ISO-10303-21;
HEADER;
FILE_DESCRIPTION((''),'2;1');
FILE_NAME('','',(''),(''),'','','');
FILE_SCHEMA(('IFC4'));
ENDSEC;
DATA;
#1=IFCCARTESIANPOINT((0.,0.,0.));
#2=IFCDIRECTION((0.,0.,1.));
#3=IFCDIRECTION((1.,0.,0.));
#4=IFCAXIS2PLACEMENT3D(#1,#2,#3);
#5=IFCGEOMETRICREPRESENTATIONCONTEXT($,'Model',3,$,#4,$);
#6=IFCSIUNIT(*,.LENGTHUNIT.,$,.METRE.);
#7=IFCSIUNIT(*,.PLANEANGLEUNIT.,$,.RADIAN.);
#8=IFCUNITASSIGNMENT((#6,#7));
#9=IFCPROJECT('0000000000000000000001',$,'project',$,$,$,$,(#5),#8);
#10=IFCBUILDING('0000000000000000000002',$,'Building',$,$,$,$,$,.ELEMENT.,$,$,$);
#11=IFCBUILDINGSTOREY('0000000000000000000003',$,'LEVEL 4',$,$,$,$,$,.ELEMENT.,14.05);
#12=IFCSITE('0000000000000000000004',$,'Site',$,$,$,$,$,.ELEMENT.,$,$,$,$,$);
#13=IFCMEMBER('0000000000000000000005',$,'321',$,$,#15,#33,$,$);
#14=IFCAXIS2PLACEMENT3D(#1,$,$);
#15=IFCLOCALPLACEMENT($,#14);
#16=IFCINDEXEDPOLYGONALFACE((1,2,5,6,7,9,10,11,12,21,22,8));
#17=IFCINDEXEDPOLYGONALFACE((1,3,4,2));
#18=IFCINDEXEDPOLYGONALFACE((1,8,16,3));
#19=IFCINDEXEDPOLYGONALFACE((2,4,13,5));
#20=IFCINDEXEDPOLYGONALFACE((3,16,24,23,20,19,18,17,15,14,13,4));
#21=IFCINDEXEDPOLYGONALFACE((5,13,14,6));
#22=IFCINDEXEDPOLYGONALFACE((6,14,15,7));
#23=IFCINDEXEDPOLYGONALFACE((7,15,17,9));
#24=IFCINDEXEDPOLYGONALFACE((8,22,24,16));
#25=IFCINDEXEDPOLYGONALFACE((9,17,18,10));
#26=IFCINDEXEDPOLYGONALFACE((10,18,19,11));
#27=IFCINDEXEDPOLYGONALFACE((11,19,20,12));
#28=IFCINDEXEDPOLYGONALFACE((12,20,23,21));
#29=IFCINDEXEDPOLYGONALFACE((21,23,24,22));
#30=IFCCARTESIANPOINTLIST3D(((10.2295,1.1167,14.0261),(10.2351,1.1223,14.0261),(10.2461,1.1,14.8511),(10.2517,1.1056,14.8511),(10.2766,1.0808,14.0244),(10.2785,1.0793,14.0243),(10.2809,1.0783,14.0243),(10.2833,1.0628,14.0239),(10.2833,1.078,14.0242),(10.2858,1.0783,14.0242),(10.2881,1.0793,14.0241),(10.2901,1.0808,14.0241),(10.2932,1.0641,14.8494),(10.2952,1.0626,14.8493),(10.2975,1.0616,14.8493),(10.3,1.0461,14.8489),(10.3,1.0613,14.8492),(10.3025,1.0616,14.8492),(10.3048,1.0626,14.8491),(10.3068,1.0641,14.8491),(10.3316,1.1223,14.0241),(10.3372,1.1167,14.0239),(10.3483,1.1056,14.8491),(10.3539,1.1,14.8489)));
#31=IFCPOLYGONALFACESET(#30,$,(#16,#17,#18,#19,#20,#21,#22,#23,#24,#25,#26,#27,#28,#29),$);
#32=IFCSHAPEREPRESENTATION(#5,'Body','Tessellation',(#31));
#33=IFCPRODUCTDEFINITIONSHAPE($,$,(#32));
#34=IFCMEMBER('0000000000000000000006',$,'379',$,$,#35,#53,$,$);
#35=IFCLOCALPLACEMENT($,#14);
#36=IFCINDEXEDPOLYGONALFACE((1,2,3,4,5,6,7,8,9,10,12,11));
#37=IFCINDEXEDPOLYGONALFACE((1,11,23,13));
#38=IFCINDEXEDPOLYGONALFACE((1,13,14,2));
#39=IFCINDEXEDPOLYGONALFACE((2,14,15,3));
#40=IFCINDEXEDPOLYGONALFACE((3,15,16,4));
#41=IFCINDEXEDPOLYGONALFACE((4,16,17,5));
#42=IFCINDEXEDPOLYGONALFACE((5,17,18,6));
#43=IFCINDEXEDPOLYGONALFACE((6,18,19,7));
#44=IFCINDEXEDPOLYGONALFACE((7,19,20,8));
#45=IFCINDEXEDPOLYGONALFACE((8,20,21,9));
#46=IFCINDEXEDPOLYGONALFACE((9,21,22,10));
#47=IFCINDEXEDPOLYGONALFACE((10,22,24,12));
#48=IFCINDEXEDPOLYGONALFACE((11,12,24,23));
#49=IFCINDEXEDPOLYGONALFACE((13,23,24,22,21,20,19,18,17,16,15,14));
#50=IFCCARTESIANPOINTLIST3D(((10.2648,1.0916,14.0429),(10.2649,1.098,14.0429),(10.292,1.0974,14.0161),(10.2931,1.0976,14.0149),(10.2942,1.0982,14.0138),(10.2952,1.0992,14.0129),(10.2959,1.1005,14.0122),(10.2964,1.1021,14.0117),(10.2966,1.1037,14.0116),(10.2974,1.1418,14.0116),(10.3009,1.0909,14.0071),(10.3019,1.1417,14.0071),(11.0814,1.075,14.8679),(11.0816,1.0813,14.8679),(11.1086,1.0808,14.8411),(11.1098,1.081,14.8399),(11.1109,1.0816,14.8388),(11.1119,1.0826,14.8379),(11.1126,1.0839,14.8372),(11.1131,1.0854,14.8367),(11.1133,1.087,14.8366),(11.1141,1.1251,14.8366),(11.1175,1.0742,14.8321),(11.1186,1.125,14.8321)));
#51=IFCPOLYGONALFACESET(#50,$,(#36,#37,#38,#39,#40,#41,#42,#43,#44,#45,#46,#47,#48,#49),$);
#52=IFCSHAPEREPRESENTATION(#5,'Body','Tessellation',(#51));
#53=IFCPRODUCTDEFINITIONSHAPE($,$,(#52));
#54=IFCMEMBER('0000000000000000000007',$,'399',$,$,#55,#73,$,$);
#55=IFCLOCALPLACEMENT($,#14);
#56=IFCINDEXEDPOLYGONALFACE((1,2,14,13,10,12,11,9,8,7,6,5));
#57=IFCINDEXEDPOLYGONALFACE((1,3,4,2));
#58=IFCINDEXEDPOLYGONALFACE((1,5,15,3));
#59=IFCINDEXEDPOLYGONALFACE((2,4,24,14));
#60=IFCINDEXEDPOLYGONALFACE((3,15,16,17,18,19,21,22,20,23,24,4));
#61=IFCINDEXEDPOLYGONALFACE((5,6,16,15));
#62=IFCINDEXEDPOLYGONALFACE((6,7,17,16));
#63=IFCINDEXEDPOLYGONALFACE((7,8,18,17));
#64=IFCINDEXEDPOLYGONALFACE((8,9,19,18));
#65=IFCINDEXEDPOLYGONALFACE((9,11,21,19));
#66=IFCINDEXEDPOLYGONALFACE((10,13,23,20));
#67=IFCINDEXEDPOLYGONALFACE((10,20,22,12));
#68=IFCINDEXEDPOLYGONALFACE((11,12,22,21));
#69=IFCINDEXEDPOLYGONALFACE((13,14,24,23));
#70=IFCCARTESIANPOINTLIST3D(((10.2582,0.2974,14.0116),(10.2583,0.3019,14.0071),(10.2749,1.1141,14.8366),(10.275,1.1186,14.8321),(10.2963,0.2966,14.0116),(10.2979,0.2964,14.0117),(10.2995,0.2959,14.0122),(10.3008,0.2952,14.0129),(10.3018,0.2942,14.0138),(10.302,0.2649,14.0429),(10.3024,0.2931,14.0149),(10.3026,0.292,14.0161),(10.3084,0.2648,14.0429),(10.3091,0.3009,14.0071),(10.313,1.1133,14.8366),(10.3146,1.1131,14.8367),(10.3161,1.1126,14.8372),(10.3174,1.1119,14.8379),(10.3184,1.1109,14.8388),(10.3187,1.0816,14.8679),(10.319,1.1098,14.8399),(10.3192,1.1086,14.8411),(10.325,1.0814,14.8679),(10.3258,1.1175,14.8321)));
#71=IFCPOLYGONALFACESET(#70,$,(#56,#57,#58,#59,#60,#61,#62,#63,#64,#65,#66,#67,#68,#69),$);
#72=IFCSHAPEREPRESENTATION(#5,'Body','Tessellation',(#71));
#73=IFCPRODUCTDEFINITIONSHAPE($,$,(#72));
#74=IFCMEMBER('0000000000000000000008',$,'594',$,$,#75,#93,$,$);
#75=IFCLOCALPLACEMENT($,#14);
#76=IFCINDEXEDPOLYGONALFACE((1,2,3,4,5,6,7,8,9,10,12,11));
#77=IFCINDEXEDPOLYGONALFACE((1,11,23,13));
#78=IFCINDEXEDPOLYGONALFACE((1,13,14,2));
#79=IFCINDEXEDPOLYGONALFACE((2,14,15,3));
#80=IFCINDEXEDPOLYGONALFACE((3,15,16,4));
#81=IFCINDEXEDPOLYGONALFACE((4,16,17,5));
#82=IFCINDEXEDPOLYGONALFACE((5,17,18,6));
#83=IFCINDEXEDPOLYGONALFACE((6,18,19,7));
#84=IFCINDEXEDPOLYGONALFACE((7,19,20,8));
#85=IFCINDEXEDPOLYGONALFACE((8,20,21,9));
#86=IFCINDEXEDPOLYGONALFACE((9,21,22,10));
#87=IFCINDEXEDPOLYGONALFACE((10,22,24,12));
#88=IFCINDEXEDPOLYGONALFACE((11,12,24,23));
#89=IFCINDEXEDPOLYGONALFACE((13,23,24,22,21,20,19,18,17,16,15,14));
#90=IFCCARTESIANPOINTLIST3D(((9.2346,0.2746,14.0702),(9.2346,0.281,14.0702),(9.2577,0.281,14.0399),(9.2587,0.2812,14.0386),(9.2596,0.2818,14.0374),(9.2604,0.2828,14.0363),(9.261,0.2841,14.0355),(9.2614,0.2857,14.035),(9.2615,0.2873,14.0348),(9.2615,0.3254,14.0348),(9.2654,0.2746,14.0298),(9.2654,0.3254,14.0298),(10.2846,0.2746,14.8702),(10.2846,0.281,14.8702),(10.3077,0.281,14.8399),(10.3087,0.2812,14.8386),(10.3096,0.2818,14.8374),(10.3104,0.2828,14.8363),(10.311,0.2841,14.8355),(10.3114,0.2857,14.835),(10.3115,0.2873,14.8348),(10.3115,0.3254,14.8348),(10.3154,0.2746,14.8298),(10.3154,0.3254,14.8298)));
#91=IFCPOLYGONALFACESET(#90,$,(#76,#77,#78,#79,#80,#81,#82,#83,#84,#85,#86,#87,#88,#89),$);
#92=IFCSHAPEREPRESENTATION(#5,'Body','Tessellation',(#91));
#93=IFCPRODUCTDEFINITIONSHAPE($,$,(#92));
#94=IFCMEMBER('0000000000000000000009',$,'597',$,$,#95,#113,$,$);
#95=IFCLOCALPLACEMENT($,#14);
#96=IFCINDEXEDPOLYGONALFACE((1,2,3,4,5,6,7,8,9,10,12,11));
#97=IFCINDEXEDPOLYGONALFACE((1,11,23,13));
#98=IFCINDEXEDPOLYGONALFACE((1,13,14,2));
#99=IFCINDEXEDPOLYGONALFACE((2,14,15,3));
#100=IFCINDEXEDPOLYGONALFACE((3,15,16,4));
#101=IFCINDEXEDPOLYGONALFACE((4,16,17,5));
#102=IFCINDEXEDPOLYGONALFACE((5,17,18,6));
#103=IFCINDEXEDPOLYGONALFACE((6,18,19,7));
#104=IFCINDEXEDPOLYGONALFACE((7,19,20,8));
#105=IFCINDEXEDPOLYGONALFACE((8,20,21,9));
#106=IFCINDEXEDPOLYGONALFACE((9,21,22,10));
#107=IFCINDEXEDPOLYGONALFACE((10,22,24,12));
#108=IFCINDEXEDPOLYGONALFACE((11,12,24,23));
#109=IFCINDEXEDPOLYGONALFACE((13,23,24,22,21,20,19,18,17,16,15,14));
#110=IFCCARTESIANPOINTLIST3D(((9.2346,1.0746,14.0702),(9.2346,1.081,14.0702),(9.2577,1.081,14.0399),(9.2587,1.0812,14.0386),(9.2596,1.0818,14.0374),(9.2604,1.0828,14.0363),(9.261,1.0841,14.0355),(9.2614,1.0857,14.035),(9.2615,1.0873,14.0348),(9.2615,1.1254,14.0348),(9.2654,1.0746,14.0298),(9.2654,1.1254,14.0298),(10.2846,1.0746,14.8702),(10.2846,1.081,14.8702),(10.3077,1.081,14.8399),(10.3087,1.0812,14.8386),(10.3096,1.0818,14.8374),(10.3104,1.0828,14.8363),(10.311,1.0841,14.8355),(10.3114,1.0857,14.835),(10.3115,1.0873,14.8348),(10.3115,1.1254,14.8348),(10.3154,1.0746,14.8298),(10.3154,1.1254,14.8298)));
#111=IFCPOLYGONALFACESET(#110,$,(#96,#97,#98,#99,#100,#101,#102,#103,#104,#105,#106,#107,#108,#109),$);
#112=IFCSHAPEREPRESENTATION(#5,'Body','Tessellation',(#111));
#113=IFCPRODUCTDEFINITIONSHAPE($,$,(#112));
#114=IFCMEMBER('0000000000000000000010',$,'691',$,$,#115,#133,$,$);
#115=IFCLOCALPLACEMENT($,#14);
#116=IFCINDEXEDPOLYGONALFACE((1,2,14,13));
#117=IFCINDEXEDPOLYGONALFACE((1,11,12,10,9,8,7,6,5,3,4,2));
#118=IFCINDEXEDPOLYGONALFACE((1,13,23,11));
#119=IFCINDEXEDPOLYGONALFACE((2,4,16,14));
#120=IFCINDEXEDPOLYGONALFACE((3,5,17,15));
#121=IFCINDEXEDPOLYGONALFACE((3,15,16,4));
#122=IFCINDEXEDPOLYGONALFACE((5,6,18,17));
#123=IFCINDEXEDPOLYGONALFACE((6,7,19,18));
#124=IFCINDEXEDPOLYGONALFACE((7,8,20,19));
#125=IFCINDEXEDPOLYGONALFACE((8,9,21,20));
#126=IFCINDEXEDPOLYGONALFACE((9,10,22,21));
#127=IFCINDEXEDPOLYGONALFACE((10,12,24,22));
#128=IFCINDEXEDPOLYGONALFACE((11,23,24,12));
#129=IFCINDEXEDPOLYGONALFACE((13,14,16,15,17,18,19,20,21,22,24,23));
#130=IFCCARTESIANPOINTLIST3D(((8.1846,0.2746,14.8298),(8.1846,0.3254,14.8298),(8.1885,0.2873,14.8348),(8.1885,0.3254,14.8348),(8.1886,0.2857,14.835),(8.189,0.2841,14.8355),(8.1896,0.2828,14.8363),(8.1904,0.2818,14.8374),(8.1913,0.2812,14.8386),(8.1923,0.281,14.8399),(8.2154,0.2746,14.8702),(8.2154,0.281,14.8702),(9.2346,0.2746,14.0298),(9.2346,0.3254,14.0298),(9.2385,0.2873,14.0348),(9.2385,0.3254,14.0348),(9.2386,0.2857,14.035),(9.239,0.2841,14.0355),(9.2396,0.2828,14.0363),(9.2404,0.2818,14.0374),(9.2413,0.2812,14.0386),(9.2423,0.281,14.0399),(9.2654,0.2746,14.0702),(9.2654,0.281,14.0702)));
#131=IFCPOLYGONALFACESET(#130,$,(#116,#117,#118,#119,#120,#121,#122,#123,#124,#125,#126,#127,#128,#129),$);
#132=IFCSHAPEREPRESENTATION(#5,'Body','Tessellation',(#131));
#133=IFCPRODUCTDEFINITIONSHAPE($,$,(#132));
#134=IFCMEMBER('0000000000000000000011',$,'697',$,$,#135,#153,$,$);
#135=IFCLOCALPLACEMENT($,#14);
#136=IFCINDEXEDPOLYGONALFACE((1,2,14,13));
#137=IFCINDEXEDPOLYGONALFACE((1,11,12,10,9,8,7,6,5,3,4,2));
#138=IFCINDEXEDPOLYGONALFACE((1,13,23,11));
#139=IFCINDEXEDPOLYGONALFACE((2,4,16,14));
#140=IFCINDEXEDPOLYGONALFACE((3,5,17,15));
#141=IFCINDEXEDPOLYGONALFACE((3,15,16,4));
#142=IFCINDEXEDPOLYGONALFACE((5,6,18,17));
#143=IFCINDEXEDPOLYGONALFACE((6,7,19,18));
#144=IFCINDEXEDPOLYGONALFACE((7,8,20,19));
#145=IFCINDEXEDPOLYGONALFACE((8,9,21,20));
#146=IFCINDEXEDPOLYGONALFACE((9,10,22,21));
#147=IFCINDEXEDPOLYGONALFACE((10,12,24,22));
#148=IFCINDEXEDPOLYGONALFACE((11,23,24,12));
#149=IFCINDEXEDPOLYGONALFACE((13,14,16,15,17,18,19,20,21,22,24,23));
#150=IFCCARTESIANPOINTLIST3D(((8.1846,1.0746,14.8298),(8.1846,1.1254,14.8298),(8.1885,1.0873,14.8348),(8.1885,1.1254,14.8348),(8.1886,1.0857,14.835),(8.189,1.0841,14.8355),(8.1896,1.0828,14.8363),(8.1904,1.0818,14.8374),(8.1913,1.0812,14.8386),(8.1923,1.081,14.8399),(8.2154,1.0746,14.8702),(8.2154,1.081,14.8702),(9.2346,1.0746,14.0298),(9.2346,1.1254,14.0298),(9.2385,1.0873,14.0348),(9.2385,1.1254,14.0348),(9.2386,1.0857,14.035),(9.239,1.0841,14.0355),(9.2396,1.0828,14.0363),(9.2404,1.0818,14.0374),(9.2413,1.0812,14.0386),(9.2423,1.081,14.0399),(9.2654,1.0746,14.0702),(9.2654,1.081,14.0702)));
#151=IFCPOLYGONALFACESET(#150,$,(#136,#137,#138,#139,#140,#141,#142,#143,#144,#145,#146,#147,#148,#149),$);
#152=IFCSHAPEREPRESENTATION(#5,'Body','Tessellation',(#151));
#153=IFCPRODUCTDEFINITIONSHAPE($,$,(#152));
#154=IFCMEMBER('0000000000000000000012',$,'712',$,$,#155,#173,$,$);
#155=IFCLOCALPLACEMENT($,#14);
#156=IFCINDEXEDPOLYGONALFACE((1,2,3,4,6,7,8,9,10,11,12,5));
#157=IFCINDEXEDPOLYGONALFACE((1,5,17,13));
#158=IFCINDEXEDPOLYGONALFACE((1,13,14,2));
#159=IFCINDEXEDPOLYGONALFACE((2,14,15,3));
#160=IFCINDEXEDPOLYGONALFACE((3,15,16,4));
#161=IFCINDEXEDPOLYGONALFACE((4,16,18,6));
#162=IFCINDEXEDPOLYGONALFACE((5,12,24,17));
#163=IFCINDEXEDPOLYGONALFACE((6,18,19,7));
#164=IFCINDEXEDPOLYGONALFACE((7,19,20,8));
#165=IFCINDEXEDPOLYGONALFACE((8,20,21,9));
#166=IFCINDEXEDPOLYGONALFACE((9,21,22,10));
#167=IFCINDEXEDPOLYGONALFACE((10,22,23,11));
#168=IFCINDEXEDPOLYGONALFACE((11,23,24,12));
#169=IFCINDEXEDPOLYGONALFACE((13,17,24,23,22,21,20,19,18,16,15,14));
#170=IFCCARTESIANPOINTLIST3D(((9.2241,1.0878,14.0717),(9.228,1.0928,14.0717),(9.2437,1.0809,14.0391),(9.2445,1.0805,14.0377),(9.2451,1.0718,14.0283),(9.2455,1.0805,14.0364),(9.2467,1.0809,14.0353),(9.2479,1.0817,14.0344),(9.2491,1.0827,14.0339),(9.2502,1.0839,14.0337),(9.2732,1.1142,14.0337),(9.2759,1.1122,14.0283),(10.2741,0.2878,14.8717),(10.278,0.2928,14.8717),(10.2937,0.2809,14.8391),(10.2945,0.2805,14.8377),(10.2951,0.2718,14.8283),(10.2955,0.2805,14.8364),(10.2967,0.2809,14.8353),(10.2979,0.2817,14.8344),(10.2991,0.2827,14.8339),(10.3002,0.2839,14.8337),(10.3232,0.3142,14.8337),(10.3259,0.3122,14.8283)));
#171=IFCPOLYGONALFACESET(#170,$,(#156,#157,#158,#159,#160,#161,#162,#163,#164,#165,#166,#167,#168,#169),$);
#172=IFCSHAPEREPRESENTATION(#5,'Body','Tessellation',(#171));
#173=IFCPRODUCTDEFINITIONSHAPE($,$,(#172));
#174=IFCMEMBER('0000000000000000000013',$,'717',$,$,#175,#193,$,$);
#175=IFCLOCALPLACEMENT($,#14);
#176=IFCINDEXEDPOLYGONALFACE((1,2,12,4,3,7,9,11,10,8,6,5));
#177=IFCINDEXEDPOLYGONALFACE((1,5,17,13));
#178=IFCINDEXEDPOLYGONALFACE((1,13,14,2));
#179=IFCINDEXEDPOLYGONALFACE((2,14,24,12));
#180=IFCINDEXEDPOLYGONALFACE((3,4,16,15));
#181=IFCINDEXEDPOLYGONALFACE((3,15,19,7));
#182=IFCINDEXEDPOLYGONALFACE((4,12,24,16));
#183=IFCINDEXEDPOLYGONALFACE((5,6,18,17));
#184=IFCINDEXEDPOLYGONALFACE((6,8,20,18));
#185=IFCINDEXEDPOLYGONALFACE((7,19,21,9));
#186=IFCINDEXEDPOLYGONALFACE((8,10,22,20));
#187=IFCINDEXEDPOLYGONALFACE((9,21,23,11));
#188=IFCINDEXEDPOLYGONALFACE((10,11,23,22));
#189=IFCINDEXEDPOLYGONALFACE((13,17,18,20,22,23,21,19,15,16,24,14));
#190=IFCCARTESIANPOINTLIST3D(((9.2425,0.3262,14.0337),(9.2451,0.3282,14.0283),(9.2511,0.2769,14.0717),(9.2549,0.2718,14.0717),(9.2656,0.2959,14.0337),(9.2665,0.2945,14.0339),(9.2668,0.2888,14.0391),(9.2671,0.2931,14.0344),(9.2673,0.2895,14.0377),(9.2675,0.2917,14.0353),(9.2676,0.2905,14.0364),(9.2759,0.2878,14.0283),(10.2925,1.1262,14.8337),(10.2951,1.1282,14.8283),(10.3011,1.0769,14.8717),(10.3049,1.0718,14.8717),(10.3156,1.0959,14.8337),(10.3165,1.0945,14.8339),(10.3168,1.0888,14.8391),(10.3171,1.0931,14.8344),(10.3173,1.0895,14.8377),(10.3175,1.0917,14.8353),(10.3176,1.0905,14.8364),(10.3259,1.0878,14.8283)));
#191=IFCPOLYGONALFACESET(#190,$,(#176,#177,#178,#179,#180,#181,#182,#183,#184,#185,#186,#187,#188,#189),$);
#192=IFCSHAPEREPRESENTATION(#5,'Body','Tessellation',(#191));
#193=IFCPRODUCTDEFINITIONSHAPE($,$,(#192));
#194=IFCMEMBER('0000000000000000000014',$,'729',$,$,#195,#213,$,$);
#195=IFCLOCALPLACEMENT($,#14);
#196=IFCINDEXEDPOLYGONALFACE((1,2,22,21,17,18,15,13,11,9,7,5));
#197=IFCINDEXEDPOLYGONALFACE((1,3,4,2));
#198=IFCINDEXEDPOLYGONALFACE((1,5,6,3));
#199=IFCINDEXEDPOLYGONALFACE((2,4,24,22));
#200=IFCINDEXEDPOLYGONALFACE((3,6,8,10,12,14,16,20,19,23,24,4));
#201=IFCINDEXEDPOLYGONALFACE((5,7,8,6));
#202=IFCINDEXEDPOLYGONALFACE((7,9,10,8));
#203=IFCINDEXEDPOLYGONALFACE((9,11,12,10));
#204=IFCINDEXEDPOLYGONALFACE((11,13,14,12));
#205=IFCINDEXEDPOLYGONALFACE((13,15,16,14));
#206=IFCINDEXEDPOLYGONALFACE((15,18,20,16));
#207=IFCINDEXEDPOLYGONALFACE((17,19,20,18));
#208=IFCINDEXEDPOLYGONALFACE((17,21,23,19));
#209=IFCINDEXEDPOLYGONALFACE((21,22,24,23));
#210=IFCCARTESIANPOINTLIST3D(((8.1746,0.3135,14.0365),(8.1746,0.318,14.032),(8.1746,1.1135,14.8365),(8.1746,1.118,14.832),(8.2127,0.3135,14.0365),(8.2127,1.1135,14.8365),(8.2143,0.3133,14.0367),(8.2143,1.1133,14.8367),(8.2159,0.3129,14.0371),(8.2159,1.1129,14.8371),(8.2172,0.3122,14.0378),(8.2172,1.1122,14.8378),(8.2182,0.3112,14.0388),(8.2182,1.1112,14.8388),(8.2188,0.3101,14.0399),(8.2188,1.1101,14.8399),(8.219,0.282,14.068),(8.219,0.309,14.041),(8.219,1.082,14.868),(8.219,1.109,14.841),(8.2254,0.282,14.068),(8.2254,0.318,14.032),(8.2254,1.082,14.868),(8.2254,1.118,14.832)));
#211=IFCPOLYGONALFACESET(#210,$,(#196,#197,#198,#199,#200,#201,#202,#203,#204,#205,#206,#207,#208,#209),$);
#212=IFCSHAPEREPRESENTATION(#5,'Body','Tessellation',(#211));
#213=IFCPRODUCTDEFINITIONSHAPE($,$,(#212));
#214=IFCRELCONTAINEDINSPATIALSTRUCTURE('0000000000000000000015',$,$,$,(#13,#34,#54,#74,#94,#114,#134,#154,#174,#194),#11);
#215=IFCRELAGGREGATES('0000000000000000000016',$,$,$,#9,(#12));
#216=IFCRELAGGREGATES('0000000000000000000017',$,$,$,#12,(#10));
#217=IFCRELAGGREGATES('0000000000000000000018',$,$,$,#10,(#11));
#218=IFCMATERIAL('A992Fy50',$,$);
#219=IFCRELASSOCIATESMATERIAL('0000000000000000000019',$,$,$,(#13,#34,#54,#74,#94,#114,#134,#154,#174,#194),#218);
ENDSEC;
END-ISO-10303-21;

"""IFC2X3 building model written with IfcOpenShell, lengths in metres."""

from ifc_helpers import new_model, si_unit, frame, origin_with_axes, origin_2d_with_axis, place, context, project, spatial, l_section, extrude, material, element, save


model = new_model("IFC2X3")

# Units and contexts
model_context = context("Model", 3, world=origin_with_axes())
ifc_project = project(units=[si_unit("LENGTHUNIT", "METRE"), si_unit("PLANEANGLEUNIT", "RADIAN")], contexts=[model_context])

# Site, building, storey
site = spatial("IfcSite", under=ifc_project, Name="Site", CompositionType="ELEMENT")
building = spatial("IfcBuilding", under=site, Name="Building", CompositionType="ELEMENT")
storey = spatial("IfcBuildingStorey", under=building, Name="LEVEL 4", CompositionType="ELEMENT", Elevation=14.05)

# Shared definitions
ifc_material = material(Name="A992Fy50")

# Members
for number, where, z_axis, x_axis, name in (
    (1, (10.2833, 1.1167, 14.025), (0.020194, -0.020194, 0.999592), (0.707107, 0.707107, 0.0), "321"),
):
    element("IfcMember", number, at=place(None, frame(where, z_axis=z_axis, x_axis=x_axis)), inside=storey, material=ifc_material, Name=name, context=model_context, shape_type="SweptSolid", body=[
        extrude(l_section(Depth=0.0762, Width=0.0762, Thickness=0.0079, FilletRadius=0.0096, at=origin_2d_with_axis()), origin_with_axes(), (0.0, 0.0, 1.0), 0.8253),
    ])
for number, where, z_axis, x_axis, name in (
    (2, (10.2833, 1.1167, 14.025), (0.703436, -0.014356, 0.710614), (0.020404, 0.999792, 0.0), "379"),
    (3, (10.2833, 0.2833, 14.025), (0.014356, 0.703436, 0.710614), (-0.999792, 0.020404, 0.0), "399"),
):
    element("IfcMember", number, at=place(None, frame(where, z_axis=z_axis, x_axis=x_axis)), inside=storey, material=ifc_material, Name=name, context=model_context, shape_type="SweptSolid", body=[
        extrude(l_section(Depth=0.0508, Width=0.0508, Thickness=0.0063, FilletRadius=0.0063, at=origin_2d_with_axis()), origin_with_axes(), (0.0, 0.0, 1.0), 1.161),
    ])
for number, where, z_axis, x_axis, name in (
    (4, (9.25, 0.3, 14.05), (0.795432, 0.0, 0.606043), (0.0, 1.0, 0.0), "594"),
    (5, (9.25, 1.1, 14.05), (0.795432, 0.0, 0.606043), (0.0, 1.0, 0.0), "597"),
    (6, (8.2, 0.3, 14.85), (0.795432, 0.0, -0.606043), (0.0, 1.0, 0.0), "691"),
    (7, (8.2, 1.1, 14.85), (0.795432, 0.0, -0.606043), (0.0, 1.0, 0.0), "697"),
):
    element("IfcMember", number, at=place(None, frame(where, z_axis=z_axis, x_axis=x_axis)), inside=storey, material=ifc_material, Name=name, context=model_context, shape_type="SweptSolid", body=[
        extrude(l_section(Depth=0.0508, Width=0.0508, Thickness=0.0063, FilletRadius=0.0063, at=origin_2d_with_axis()), origin_with_axes(), (0.0, 0.0, 1.0), 1.32),
    ])
for number, where, z_axis, x_axis, name in (
    (8, (9.25, 1.1, 14.05), (0.680257, -0.518291, 0.518291), (0.606043, 0.795432, 0.0), "712"),
    (9, (9.25, 0.3, 14.05), (0.680257, 0.518291, 0.518291), (-0.606043, 0.795432, 0.0), "717"),
):
    element("IfcMember", number, at=place(None, frame(where, z_axis=z_axis, x_axis=x_axis)), inside=storey, material=ifc_material, Name=name, context=model_context, shape_type="SweptSolid", body=[
        extrude(l_section(Depth=0.0508, Width=0.0508, Thickness=0.0063, FilletRadius=0.0063, at=origin_2d_with_axis()), origin_with_axes(), (0.0, 0.0, 1.0), 1.5435),
    ])
for number, where, z_axis, x_axis, name in (
    (10, (8.2, 0.3, 14.05), (0.0, 0.707107, 0.707107), (-1.0, 0.0, 0.0), "729"),
):
    element("IfcMember", number, at=place(None, frame(where, z_axis=z_axis, x_axis=x_axis)), inside=storey, material=ifc_material, Name=name, context=model_context, shape_type="SweptSolid", body=[
        extrude(l_section(Depth=0.0508, Width=0.0508, Thickness=0.0063, FilletRadius=0.0063, at=origin_2d_with_axis()), origin_with_axes(), (0.0, 0.0, 1.0), 1.1314),
    ])

save(model, "model.ifc")
